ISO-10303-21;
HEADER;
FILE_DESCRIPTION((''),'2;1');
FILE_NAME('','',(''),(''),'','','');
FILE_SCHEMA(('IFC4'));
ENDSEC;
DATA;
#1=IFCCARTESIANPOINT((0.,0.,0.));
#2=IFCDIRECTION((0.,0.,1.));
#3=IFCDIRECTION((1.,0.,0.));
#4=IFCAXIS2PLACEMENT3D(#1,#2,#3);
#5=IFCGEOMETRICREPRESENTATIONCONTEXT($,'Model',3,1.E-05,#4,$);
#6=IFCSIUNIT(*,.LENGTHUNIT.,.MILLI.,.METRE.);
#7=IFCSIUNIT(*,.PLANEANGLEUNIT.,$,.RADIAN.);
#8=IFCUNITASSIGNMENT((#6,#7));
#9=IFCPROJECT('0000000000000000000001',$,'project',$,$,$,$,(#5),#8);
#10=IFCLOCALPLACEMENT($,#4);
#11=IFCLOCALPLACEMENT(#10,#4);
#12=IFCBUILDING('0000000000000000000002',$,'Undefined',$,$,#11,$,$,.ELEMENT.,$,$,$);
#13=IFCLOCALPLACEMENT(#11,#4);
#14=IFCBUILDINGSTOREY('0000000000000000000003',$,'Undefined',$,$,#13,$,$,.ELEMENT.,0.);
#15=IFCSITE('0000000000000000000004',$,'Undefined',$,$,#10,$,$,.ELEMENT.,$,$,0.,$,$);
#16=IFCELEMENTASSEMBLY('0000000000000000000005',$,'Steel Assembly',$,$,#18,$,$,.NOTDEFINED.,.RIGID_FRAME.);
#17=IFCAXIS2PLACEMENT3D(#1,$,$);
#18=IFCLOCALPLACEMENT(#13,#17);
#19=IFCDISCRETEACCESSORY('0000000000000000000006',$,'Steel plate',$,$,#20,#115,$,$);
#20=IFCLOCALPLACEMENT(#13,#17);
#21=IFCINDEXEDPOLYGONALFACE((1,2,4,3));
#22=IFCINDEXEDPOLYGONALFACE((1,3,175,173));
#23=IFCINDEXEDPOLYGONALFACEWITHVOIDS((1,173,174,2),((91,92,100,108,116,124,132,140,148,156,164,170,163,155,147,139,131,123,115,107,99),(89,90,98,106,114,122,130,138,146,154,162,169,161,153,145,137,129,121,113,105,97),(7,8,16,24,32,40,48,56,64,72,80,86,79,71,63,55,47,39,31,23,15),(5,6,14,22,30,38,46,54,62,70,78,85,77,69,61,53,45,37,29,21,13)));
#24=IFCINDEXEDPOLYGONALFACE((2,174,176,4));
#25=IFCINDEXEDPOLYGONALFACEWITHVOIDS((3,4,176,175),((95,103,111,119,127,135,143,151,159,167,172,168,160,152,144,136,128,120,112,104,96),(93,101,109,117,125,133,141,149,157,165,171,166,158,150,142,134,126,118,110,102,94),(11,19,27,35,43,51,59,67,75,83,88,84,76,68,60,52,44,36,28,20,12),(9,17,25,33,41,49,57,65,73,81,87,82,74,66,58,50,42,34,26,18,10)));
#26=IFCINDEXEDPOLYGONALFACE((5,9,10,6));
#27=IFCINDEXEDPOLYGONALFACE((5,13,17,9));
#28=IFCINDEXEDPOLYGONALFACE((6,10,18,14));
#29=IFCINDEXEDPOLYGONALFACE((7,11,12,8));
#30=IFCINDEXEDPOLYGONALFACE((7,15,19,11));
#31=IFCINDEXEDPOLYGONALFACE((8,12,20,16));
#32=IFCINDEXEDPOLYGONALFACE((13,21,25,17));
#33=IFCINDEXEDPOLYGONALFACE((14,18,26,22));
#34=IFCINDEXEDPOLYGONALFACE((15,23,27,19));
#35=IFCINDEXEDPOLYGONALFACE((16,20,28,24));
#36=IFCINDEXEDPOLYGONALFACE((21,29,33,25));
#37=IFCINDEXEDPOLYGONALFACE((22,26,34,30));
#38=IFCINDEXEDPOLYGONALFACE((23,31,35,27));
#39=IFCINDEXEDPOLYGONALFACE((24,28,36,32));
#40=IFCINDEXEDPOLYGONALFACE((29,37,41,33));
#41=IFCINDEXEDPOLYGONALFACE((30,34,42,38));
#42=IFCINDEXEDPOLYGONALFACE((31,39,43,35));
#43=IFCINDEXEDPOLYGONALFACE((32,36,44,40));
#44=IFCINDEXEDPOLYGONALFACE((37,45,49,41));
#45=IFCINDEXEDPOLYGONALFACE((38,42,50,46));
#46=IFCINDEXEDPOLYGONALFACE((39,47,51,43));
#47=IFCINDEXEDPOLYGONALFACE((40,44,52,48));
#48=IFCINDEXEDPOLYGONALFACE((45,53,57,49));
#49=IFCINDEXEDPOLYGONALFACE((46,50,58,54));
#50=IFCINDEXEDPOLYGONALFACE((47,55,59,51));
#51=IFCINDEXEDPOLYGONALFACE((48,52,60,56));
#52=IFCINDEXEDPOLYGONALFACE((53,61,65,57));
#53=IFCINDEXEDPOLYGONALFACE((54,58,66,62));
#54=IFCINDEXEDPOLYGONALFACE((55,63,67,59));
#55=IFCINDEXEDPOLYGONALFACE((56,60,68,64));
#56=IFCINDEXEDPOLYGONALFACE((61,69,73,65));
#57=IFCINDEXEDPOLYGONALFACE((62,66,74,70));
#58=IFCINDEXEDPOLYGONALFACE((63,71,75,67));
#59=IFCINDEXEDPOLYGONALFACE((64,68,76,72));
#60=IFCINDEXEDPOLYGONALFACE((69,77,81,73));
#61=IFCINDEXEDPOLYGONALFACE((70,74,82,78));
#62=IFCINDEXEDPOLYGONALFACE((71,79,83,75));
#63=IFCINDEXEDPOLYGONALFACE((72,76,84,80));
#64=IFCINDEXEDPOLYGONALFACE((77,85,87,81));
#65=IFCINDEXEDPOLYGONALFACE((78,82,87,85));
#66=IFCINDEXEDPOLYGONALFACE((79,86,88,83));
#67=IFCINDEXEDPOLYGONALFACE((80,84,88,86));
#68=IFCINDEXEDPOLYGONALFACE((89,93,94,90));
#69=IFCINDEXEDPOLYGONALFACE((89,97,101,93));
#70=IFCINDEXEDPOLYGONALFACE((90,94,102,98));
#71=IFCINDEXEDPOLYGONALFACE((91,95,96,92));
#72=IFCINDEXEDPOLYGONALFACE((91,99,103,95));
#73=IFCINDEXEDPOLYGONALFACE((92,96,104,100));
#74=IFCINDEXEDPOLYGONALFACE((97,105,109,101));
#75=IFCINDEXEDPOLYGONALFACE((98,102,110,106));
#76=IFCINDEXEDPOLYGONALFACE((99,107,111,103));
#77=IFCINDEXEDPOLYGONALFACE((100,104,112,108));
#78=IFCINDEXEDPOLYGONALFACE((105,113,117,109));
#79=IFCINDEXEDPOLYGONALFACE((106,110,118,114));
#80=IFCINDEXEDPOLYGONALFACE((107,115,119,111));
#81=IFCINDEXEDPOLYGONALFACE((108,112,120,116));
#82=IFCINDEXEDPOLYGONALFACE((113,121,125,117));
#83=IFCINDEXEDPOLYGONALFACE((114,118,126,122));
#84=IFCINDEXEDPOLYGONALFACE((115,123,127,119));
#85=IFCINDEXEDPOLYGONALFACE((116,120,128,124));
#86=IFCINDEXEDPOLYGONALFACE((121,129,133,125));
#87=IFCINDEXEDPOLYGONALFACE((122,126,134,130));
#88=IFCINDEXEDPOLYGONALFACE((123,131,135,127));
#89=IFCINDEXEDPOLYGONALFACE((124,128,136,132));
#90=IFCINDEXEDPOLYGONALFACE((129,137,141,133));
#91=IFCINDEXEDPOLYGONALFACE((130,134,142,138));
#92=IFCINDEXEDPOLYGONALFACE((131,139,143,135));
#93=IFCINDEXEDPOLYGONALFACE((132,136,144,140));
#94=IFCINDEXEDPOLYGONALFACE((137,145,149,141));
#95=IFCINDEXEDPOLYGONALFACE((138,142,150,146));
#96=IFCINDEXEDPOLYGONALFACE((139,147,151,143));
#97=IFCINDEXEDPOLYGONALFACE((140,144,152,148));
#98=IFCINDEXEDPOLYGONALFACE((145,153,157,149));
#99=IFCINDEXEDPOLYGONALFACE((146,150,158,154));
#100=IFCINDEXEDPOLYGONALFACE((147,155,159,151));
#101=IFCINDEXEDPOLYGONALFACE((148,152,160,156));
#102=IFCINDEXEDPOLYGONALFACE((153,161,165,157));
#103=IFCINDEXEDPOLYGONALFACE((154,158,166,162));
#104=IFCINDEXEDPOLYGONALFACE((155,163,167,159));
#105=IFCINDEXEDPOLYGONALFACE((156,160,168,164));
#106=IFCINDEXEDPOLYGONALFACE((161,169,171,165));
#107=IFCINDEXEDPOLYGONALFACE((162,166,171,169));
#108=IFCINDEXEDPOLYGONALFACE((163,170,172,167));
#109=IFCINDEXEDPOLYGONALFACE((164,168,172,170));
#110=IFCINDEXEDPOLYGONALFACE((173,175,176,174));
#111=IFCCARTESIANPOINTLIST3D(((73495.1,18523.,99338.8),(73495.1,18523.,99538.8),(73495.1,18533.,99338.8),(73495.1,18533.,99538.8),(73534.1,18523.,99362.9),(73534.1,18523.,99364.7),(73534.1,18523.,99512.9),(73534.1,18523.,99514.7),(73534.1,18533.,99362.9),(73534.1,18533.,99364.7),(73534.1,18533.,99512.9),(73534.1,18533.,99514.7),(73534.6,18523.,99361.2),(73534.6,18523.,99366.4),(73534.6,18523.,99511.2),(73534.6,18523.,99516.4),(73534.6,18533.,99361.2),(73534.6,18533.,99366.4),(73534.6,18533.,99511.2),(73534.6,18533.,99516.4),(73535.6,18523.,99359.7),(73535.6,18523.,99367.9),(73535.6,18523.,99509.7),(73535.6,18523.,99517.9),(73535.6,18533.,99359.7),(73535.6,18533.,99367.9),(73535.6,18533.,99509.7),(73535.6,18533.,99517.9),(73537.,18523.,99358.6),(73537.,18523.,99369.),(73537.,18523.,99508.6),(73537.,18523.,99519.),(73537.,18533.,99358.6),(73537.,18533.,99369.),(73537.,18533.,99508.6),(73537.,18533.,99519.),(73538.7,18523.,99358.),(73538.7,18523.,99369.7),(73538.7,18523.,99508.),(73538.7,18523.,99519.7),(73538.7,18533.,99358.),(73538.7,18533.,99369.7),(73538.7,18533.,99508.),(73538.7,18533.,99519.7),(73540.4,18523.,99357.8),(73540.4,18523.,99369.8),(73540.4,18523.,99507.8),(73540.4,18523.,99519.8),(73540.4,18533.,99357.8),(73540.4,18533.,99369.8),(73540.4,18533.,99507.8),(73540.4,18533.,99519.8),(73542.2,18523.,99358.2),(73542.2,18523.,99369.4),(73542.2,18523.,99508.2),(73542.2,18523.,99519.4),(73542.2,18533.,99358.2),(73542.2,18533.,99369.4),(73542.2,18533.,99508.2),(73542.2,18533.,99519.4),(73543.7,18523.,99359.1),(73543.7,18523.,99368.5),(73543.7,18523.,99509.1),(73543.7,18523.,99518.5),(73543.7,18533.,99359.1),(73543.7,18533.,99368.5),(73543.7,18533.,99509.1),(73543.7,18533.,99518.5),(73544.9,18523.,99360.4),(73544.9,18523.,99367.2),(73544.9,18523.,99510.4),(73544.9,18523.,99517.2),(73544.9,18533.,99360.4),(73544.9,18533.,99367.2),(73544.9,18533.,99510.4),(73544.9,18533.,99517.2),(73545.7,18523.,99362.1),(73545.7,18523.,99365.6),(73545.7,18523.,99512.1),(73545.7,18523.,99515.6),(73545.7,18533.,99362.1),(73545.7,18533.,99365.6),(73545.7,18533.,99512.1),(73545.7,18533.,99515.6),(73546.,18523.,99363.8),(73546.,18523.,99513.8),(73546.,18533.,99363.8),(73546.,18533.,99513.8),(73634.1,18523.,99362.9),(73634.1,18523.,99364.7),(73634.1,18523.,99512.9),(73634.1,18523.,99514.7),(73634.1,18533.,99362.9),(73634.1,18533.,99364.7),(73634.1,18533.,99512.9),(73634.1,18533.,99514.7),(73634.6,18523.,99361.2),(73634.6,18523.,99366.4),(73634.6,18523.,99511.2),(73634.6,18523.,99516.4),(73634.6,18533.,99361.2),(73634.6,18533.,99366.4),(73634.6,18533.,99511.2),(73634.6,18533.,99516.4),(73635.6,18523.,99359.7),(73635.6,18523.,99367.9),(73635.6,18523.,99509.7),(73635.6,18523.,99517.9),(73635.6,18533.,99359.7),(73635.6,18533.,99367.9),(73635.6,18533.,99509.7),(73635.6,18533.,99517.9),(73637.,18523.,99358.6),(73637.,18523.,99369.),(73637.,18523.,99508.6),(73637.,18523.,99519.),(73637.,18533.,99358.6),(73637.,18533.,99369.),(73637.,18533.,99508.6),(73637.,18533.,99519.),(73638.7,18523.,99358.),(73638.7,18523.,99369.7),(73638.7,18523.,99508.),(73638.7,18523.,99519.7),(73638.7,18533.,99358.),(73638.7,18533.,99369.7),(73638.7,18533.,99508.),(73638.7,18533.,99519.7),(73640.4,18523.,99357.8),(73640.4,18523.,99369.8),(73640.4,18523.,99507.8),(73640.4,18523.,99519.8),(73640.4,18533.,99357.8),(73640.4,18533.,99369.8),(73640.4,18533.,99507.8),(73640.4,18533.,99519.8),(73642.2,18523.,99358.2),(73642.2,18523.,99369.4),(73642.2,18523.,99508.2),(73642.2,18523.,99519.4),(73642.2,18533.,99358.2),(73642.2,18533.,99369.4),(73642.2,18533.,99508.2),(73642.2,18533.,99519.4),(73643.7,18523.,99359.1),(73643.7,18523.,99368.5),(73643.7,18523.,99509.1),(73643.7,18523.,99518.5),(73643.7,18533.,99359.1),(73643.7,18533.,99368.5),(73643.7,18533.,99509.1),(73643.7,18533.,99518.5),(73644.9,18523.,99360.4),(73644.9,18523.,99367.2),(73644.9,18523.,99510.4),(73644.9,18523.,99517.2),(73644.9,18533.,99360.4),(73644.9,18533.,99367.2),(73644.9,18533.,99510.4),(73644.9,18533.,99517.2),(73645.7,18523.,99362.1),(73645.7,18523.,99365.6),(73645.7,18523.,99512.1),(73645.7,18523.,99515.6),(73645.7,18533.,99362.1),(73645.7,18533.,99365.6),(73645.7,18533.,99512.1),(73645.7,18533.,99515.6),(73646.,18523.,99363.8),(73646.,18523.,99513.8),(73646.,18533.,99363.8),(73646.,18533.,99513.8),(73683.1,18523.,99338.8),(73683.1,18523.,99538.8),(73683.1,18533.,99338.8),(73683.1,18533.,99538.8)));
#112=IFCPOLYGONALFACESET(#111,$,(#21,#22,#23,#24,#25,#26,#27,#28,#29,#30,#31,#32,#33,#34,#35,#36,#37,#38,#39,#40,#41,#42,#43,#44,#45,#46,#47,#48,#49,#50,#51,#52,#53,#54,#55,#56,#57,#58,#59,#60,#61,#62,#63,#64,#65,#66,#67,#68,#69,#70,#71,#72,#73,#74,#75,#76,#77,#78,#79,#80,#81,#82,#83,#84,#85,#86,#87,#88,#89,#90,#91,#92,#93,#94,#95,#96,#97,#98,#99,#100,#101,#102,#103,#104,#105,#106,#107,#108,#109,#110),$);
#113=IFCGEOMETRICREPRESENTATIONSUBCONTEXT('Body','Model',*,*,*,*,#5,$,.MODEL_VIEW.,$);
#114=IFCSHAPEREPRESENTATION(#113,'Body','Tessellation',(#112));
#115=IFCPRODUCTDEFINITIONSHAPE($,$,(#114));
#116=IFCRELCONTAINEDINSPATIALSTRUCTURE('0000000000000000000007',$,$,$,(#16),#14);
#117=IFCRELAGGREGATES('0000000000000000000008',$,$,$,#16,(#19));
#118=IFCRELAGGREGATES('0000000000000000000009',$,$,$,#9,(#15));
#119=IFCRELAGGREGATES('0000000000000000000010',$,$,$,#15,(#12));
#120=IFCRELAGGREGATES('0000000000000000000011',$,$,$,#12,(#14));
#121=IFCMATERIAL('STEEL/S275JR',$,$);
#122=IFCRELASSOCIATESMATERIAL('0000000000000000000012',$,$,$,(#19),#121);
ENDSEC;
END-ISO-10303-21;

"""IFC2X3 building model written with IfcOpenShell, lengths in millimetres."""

from ifc_helpers import new_model, si_unit, frame, origin_with_axes, origin_2d_with_axis, place, context, subcontext, project, spatial, polyline, circle, outline, extrude, source, transform, mapped, material, element, aggregate, save


model = new_model("IFC2X3")

# Units and contexts
model_context = context("Model", 3, precision=1e-05, world=origin_with_axes())
body_context = subcontext(model_context, "Body", "Model", "MODEL_VIEW")
ifc_project = project(units=[si_unit("LENGTHUNIT", "METRE", prefix="MILLI"), si_unit("PLANEANGLEUNIT", "RADIAN")], contexts=[model_context])

# Site, building, storey
site_placement = place(None, origin_with_axes())
site = spatial("IfcSite", under=ifc_project, at=site_placement, Name="Undefined", CompositionType="ELEMENT", RefElevation=0.0)
building_placement = place(site_placement, origin_with_axes())
building = spatial("IfcBuilding", under=site, at=building_placement, Name="Undefined", CompositionType="ELEMENT")
storey_placement = place(building_placement, origin_with_axes())
storey = spatial("IfcBuildingStorey", under=building, at=storey_placement, Name="Undefined", CompositionType="ELEMENT", Elevation=0.0)

# Element assembly
assembly_1_placement = place(storey_placement, origin_with_axes())
assembly_1 = element("IfcElementAssembly", 1, at=assembly_1_placement, inside=storey, Name="Steel Assembly", AssemblyPlace="NOTDEFINED", PredefinedType="RIGID_FRAME")

# Discrete accessory, opening
ifc_material_1 = material(Name="STEEL/S275JR")
discrete_accessory_1_placement = place(assembly_1_placement, frame((73683.1, 18528.0, 99538.8), z_axis=(0.0, -1.0, 0.0), x_axis=(-1.0, 0.0, 0.0)))
discrete_accessory_1 = element("IfcDiscreteAccessory", 2, at=discrete_accessory_1_placement, material=ifc_material_1, Name="Steel plate", context=body_context, shape_type="SweptSolid", body=[
    extrude(outline(polyline([(0.0, 0.0), (188.0, 0.0), (188.0, 200.0), (0.0, 200.0), (0.0, 0.0)])), frame((0.0, 0.0, -5.0), z_axis=(0.0, 0.0, 1.0), x_axis=(1.0, 0.0, 0.0)), (0.0, 0.0, 1.0), 10.0),
])
shared_shape_1 = source(origin_with_axes(), body_context, "Body", "SweptSolid", [
    extrude(circle(Radius=6.0, at=origin_2d_with_axis()), frame((0.0, -0.2, 0.0), z_axis=(0.0, 1.0, 0.0), x_axis=(1.0, 0.0, 0.0)), (0.0, 0.0, 1.0), 10.2),
])
opening_1_placement = place(assembly_1_placement, frame((73540.0, 18523.1, 99438.8), z_axis=(0.0, 0.0, 1.0), x_axis=(1.0, 0.0, 0.0)))
element("IfcOpeningElement", 3, at=opening_1_placement, cuts=discrete_accessory_1, ObjectType="Opening", context=body_context, shape_type="MappedRepresentation", body=[
    mapped(shared_shape_1, transform((0.0, 0.0, -75.0))),
    mapped(shared_shape_1, transform((100.0, 0.0, -75.0))),
    mapped(shared_shape_1, transform((0.0, 0.0, 75.0))),
    mapped(shared_shape_1, transform((100.0, 0.0, 75.0))),
])

aggregate(assembly_1, [discrete_accessory_1])

save(model, "model.ifc")
